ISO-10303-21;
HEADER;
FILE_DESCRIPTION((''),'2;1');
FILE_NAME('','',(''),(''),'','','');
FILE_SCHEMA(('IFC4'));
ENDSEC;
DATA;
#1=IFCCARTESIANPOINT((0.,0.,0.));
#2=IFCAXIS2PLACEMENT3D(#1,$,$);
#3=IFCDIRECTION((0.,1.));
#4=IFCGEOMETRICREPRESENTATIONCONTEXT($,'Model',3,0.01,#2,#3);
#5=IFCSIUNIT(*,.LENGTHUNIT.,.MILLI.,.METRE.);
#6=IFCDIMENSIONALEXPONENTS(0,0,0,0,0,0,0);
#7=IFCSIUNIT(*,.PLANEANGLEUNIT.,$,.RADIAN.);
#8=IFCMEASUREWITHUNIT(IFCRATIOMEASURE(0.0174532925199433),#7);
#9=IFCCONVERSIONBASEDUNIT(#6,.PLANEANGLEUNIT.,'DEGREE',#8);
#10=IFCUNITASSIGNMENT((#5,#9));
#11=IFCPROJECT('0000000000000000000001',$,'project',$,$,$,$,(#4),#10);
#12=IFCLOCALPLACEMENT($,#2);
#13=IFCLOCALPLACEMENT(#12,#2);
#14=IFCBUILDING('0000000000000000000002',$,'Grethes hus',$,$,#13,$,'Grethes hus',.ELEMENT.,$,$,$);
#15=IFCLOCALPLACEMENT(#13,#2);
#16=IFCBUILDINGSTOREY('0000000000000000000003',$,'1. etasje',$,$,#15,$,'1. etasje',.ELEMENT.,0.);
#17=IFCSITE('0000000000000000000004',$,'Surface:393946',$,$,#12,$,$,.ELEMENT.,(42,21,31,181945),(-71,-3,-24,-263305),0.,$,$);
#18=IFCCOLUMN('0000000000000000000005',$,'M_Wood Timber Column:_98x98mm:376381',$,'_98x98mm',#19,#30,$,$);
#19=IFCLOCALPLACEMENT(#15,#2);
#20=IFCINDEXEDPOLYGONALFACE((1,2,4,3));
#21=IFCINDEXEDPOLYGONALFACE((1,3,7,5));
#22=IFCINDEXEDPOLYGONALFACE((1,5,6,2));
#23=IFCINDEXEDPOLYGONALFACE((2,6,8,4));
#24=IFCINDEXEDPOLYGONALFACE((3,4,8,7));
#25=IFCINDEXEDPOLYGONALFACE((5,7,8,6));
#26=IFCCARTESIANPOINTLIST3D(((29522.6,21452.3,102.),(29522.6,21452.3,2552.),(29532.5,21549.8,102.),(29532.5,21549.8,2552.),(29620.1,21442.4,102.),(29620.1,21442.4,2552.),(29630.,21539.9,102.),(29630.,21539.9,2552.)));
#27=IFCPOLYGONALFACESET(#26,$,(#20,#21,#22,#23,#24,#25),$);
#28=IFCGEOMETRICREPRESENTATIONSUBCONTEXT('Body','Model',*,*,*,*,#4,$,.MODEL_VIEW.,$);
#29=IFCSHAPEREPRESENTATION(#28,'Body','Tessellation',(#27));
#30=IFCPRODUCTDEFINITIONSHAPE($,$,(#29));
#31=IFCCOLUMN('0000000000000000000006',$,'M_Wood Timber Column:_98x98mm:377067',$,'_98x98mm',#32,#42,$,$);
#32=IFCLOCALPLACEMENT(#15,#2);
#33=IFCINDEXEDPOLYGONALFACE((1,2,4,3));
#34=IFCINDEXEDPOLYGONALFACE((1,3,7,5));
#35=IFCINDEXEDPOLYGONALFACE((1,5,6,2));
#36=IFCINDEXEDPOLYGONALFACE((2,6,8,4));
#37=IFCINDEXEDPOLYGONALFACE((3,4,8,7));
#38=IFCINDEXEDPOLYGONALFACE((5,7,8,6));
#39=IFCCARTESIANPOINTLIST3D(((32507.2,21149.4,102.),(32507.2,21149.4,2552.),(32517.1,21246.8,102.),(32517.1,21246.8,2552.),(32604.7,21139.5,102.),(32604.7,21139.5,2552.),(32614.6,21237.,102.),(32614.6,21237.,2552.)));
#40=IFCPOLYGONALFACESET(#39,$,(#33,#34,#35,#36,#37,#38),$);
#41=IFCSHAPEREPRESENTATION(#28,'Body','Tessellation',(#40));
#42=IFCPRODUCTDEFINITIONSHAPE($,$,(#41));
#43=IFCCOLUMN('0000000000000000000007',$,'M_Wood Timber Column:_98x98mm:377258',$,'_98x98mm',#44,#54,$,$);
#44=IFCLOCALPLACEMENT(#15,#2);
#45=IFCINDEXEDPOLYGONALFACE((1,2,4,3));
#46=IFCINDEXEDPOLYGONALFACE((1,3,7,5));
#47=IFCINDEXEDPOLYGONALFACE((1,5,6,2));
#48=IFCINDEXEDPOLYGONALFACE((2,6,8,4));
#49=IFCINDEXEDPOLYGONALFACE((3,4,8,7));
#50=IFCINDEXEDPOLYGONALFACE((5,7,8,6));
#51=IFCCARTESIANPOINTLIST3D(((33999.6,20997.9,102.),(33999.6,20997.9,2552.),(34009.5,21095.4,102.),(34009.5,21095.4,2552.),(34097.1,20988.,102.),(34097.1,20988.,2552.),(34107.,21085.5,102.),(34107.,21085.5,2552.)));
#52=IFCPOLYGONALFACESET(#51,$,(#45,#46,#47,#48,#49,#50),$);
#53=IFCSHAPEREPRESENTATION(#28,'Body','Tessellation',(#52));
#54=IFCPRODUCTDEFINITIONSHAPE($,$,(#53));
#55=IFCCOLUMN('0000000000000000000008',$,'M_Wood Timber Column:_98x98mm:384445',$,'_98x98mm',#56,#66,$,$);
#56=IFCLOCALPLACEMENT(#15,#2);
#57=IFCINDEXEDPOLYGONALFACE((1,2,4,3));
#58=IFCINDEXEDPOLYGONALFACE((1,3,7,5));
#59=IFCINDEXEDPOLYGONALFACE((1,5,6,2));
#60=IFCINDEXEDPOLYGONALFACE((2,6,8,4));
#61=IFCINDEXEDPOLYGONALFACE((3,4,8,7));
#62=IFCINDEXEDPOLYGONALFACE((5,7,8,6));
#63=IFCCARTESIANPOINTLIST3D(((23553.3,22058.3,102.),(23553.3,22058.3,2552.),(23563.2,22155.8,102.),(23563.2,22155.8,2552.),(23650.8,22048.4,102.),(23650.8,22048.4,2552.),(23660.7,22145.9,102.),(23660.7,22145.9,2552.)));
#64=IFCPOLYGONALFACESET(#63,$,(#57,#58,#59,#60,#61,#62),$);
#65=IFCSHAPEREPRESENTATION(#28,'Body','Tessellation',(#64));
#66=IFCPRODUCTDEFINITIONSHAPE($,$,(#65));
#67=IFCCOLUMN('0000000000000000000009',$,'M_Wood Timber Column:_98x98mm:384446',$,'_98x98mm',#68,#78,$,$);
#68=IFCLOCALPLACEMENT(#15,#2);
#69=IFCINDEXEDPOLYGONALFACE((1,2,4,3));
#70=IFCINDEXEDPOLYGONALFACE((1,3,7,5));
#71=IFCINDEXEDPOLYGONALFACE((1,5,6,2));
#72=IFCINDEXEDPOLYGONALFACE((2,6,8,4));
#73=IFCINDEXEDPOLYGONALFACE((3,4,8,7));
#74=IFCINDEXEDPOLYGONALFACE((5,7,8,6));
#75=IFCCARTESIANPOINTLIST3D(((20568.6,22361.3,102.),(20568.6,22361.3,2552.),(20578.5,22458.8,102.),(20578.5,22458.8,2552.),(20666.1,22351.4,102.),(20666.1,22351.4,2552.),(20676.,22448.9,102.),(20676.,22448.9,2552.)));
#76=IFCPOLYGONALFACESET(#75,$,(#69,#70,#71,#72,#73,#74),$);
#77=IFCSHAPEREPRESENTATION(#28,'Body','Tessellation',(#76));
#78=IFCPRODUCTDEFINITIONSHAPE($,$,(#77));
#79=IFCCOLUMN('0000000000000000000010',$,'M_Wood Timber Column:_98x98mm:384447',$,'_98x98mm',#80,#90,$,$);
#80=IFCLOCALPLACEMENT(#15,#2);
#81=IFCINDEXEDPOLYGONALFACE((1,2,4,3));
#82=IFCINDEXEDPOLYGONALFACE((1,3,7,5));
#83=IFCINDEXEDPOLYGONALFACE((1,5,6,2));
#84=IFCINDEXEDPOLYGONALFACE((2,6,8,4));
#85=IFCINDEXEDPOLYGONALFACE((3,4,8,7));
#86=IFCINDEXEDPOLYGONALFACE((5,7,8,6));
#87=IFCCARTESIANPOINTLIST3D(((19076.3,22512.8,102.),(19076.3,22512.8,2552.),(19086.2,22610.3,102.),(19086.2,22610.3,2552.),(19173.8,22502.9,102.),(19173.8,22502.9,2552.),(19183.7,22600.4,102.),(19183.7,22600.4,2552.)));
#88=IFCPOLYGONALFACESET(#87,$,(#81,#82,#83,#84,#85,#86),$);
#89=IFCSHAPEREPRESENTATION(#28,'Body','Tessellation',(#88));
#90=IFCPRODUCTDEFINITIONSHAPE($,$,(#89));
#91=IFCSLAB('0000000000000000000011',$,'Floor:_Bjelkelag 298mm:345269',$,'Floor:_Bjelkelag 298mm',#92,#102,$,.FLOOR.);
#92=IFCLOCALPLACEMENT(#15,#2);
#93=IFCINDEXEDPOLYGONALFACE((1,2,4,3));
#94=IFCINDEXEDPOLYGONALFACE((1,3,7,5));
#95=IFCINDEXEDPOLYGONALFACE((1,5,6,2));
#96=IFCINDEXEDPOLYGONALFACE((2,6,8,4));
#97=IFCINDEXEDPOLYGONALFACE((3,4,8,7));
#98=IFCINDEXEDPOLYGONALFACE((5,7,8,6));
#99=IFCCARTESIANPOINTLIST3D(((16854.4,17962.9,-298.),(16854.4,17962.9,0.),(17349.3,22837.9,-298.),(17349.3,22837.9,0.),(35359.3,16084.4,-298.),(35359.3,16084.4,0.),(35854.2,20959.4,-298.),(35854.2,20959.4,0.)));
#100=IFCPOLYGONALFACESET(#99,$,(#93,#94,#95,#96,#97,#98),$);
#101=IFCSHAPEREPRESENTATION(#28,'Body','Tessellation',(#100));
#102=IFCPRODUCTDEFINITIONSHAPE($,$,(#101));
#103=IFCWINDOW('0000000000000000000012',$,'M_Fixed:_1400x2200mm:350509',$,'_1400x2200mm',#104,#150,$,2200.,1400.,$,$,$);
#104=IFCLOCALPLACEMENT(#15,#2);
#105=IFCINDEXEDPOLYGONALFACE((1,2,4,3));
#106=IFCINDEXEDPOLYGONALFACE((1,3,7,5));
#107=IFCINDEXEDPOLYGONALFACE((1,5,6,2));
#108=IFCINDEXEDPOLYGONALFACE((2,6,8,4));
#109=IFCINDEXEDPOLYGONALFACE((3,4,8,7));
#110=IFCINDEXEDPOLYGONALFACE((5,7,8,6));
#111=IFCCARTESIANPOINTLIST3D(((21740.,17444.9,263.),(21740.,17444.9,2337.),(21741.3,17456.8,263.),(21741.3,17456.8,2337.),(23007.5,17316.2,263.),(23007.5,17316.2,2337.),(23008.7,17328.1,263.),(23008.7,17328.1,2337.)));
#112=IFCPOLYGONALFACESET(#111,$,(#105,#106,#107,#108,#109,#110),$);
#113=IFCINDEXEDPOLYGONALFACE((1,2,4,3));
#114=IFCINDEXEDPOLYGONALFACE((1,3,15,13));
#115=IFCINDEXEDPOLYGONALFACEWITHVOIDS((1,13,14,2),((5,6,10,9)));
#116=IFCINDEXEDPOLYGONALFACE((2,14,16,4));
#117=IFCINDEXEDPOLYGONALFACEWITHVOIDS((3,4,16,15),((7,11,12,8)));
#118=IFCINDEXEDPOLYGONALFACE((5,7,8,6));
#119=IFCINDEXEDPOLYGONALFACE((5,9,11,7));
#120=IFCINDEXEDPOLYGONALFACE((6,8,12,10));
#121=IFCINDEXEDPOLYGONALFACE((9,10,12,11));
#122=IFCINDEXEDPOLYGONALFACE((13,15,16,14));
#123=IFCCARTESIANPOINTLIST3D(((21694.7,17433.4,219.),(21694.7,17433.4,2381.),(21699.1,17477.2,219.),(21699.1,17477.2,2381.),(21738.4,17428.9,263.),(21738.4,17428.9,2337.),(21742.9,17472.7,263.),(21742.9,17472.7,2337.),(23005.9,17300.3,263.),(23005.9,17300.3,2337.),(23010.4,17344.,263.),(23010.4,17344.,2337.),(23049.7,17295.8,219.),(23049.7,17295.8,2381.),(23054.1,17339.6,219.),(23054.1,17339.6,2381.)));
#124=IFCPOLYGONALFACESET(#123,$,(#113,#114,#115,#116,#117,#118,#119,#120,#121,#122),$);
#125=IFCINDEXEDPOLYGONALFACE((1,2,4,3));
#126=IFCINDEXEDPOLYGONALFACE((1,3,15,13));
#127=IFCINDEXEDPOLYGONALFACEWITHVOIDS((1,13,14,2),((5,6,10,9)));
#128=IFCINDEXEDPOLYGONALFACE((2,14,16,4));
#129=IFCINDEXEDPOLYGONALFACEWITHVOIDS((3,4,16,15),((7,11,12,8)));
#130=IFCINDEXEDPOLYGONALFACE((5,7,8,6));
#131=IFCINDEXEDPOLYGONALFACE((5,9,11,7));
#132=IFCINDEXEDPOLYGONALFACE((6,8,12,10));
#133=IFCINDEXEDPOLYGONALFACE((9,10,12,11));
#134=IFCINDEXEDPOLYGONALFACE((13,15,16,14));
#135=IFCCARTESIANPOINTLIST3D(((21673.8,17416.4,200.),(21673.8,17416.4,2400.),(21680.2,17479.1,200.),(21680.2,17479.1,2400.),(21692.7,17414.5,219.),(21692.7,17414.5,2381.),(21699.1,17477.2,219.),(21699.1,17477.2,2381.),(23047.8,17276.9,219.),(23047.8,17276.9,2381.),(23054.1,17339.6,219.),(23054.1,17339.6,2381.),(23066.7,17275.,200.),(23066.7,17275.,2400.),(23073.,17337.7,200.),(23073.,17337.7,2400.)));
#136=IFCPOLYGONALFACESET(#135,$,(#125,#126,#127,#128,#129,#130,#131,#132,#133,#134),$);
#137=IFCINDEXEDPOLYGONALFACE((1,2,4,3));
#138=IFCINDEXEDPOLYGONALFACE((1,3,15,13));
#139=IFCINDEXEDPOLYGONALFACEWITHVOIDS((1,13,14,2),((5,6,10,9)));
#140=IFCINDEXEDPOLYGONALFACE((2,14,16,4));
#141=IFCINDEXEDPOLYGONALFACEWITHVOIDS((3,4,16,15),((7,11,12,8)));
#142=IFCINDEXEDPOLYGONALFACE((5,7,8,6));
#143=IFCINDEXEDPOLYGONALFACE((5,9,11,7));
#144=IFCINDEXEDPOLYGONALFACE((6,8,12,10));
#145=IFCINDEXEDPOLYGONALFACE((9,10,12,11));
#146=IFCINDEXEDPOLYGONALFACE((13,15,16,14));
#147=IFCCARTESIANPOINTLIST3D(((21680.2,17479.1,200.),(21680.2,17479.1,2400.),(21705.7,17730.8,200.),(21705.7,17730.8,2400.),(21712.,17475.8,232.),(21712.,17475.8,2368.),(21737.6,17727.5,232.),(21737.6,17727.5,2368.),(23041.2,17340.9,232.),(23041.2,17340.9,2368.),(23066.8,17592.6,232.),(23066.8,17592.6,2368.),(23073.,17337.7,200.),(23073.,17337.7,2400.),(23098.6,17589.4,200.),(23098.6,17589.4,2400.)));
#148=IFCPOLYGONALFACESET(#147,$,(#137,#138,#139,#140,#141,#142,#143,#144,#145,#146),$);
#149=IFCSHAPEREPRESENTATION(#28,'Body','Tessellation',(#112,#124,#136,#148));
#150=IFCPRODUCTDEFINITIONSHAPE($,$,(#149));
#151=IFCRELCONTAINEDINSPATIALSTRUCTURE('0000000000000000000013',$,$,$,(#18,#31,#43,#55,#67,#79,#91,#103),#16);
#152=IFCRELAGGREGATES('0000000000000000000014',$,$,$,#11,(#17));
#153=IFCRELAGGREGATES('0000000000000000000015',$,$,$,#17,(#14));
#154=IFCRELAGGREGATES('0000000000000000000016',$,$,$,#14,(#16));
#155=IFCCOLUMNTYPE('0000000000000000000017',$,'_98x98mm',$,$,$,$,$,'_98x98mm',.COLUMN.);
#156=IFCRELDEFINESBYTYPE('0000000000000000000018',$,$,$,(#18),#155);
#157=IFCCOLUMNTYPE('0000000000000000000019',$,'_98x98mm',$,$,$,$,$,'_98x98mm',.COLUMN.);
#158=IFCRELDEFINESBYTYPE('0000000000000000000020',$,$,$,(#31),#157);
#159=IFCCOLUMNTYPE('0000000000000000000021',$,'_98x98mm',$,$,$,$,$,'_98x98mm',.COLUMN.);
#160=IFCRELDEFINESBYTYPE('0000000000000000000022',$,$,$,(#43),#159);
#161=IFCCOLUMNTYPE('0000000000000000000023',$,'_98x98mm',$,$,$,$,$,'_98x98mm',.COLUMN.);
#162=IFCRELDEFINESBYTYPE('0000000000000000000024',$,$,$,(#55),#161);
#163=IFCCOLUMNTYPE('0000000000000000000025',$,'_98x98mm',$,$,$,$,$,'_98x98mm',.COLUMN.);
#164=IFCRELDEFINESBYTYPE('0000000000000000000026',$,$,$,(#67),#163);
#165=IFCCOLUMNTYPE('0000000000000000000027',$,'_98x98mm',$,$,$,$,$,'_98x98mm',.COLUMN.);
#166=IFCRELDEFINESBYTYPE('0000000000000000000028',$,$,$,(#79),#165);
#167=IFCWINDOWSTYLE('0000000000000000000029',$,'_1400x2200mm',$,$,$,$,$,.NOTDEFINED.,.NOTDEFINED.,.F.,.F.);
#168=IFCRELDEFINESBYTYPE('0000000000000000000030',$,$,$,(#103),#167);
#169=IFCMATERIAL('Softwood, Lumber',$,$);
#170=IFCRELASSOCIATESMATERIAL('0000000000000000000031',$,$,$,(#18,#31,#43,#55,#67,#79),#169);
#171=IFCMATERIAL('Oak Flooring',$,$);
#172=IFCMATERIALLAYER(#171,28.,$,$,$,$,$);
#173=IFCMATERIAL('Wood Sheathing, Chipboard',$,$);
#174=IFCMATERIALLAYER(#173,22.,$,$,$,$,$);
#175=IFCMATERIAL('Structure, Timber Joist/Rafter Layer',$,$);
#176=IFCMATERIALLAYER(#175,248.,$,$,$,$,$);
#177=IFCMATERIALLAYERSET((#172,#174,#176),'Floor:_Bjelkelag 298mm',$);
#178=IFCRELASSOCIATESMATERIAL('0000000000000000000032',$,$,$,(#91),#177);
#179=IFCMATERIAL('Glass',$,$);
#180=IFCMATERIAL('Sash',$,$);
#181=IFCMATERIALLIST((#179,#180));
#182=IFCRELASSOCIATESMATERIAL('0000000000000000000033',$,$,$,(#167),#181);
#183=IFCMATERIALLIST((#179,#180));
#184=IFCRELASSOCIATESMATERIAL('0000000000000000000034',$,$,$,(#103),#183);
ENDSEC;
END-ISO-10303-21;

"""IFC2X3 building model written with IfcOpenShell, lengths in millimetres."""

from ifc_helpers import new_model, entity, si_unit, converted_unit, direction, frame, frame_2d, origin, place, context, subcontext, project, spatial, polyline, rectangle, outline, extrude, source, transform, mapped, material, material_list, layer, layer_set, layer_usage, type_object, type_shapes, element, save


model = new_model("IFC2X3")

# Units and contexts
model_context = context("Model", 3, precision=0.01, world=origin(), true_north=direction((0.0, 1.0)))
body_context = subcontext(model_context, "Body", "Model", "MODEL_VIEW")
ifc_project = project(units=[si_unit("LENGTHUNIT", "METRE", prefix="MILLI"), converted_unit("PLANEANGLEUNIT", "DEGREE", entity("IfcRatioMeasure", 0.0174532925199433), si_unit("PLANEANGLEUNIT", "RADIAN"), dimensions=[0, 0, 0, 0, 0, 0, 0])], contexts=[model_context])

# Site, building, storey
site_placement = place(None, origin())
site = spatial("IfcSite", under=ifc_project, at=site_placement, Name="Surface:393946", CompositionType="ELEMENT", RefLatitude=(42, 21, 31, 181945), RefLongitude=(-71, -3, -24, -263305), RefElevation=0.0)
building_placement = place(site_placement, origin())
building = spatial("IfcBuilding", under=site, at=building_placement, Name="Grethes hus", LongName="Grethes hus", CompositionType="ELEMENT")
storey_placement = place(building_placement, origin())
storey = spatial("IfcBuildingStorey", under=building, at=storey_placement, Name="1. etasje", LongName="1. etasje", CompositionType="ELEMENT", Elevation=0.0)

# Columns
ifc_material_1 = material(Name="Softwood, Lumber")
column_type_1 = type_object("IfcColumnType", Name="_98x98mm", ElementType="_98x98mm", PredefinedType="COLUMN")
shared_shape_1 = source(origin(), body_context, "Body", "SweptSolid", [
    extrude(rectangle(XDim=98.0, YDim=98.0, at=frame_2d((0.0, 0.0), x_axis=(1.0, 0.0))), frame((29576.3, 21496.1, 102.0), z_axis=(0.0, 0.0, 1.0), x_axis=(0.100996, 0.994887, 0.0)), (0.0, 0.0, 1.0), 2450.0),
])
type_shapes(column_type_1, [shared_shape_1])
column_1_placement = place(storey_placement, origin())
element("IfcColumn", 1, at=column_1_placement, inside=storey, type_object=column_type_1, material=ifc_material_1, Name="M_Wood Timber Column:_98x98mm:376381", ObjectType="_98x98mm", context=body_context, shape_type="MappedRepresentation", body=[
    mapped(shared_shape_1, transform((0.0, 0.0, 0.0), scale=1.0)),
])
column_type_2 = type_object("IfcColumnType", Name="_98x98mm", ElementType="_98x98mm", PredefinedType="COLUMN")
shared_shape_2 = source(origin(), body_context, "Body", "SweptSolid", [
    extrude(rectangle(XDim=98.0, YDim=98.0, at=frame_2d((0.0, 0.0), x_axis=(1.0, 0.0))), frame((32560.9, 21193.2, 102.0), z_axis=(0.0, 0.0, 1.0), x_axis=(0.100996, 0.994887, 0.0)), (0.0, 0.0, 1.0), 2450.0),
])
type_shapes(column_type_2, [shared_shape_2])
column_2_placement = place(storey_placement, origin())
element("IfcColumn", 2, at=column_2_placement, inside=storey, type_object=column_type_2, material=ifc_material_1, Name="M_Wood Timber Column:_98x98mm:377067", ObjectType="_98x98mm", context=body_context, shape_type="MappedRepresentation", body=[
    mapped(shared_shape_2, transform((0.0, 0.0, 0.0), scale=1.0)),
])
column_type_3 = type_object("IfcColumnType", Name="_98x98mm", ElementType="_98x98mm", PredefinedType="COLUMN")
shared_shape_3 = source(origin(), body_context, "Body", "SweptSolid", [
    extrude(rectangle(XDim=98.0, YDim=98.0, at=frame_2d((0.0, 0.0), x_axis=(1.0, 0.0))), frame((34053.3, 21041.7, 102.0), z_axis=(0.0, 0.0, 1.0), x_axis=(0.100996, 0.994887, 0.0)), (0.0, 0.0, 1.0), 2450.0),
])
type_shapes(column_type_3, [shared_shape_3])
column_3_placement = place(storey_placement, origin())
element("IfcColumn", 3, at=column_3_placement, inside=storey, type_object=column_type_3, material=ifc_material_1, Name="M_Wood Timber Column:_98x98mm:377258", ObjectType="_98x98mm", context=body_context, shape_type="MappedRepresentation", body=[
    mapped(shared_shape_3, transform((0.0, 0.0, 0.0), scale=1.0)),
])
column_type_4 = type_object("IfcColumnType", Name="_98x98mm", ElementType="_98x98mm", PredefinedType="COLUMN")
shared_shape_4 = source(origin(), body_context, "Body", "SweptSolid", [
    extrude(rectangle(XDim=98.0, YDim=98.0, at=frame_2d((0.0, 0.0), x_axis=(1.0, 0.0))), frame((23607.0, 22102.1, 102.0), z_axis=(0.0, 0.0, 1.0), x_axis=(0.100996, 0.994887, 0.0)), (0.0, 0.0, 1.0), 2450.0),
])
type_shapes(column_type_4, [shared_shape_4])
column_4_placement = place(storey_placement, origin())
element("IfcColumn", 4, at=column_4_placement, inside=storey, type_object=column_type_4, material=ifc_material_1, Name="M_Wood Timber Column:_98x98mm:384445", ObjectType="_98x98mm", context=body_context, shape_type="MappedRepresentation", body=[
    mapped(shared_shape_4, transform((0.0, 0.0, 0.0), scale=1.0)),
])
column_type_5 = type_object("IfcColumnType", Name="_98x98mm", ElementType="_98x98mm", PredefinedType="COLUMN")
shared_shape_5 = source(origin(), body_context, "Body", "SweptSolid", [
    extrude(rectangle(XDim=98.0, YDim=98.0, at=frame_2d((0.0, 0.0), x_axis=(1.0, 0.0))), frame((20622.3, 22405.1, 102.0), z_axis=(0.0, 0.0, 1.0), x_axis=(0.100996, 0.994887, 0.0)), (0.0, 0.0, 1.0), 2450.0),
])
type_shapes(column_type_5, [shared_shape_5])
column_5_placement = place(storey_placement, origin())
element("IfcColumn", 5, at=column_5_placement, inside=storey, type_object=column_type_5, material=ifc_material_1, Name="M_Wood Timber Column:_98x98mm:384446", ObjectType="_98x98mm", context=body_context, shape_type="MappedRepresentation", body=[
    mapped(shared_shape_5, transform((0.0, 0.0, 0.0), scale=1.0)),
])
column_type_6 = type_object("IfcColumnType", Name="_98x98mm", ElementType="_98x98mm", PredefinedType="COLUMN")
shared_shape_6 = source(origin(), body_context, "Body", "SweptSolid", [
    extrude(rectangle(XDim=98.0, YDim=98.0, at=frame_2d((0.0, 0.0), x_axis=(1.0, 0.0))), frame((19130.0, 22556.6, 102.0), z_axis=(0.0, 0.0, 1.0), x_axis=(0.100996, 0.994887, 0.0)), (0.0, 0.0, 1.0), 2450.0),
])
type_shapes(column_type_6, [shared_shape_6])
column_6_placement = place(storey_placement, origin())
element("IfcColumn", 6, at=column_6_placement, inside=storey, type_object=column_type_6, material=ifc_material_1, Name="M_Wood Timber Column:_98x98mm:384447", ObjectType="_98x98mm", context=body_context, shape_type="MappedRepresentation", body=[
    mapped(shared_shape_6, transform((0.0, 0.0, 0.0), scale=1.0)),
])

# Slab
ifc_material_2 = material(Name="Oak Flooring")
ifc_layer_1 = layer(ifc_material_2, 28.0)
ifc_material_3 = material(Name="Wood Sheathing, Chipboard")
ifc_layer_2 = layer(ifc_material_3, 22.0)
ifc_material_4 = material(Name="Structure, Timber Joist/Rafter Layer")
ifc_layer_3 = layer(ifc_material_4, 248.0)
ifc_layer_set = layer_set([ifc_layer_1, ifc_layer_2, ifc_layer_3], Name="Floor:_Bjelkelag 298mm")
ifc_layer_usage_1 = layer_usage(ifc_layer_set, "AXIS3", "POSITIVE", 0.0)
slab_1_placement = place(storey_placement, origin())
element("IfcSlab", 7, at=slab_1_placement, inside=storey, material=ifc_layer_usage_1, Name="Floor:_Bjelkelag 298mm:345269", ObjectType="Floor:_Bjelkelag 298mm", PredefinedType="FLOOR", context=body_context, shape_type="SweptSolid", body=[
    extrude(rectangle(XDim=18600.0, YDim=4900.0, at=frame_2d((0.0, 0.0), x_axis=(1.0, 0.0))), frame((26354.3, 19461.1, 0.0), z_axis=(0.0, 0.0, -1.0), x_axis=(0.994887, -0.100996, 0.0)), (0.0, 0.0, 1.0), 298.0),
])

# Window
ifc_material_5 = material(Name="Glass")
ifc_material_6 = material(Name="Sash")
ifc_material_list_1 = material_list([ifc_material_5, ifc_material_6])
ifc_material_list_2 = material_list([ifc_material_5, ifc_material_6])
window_style_1 = type_object("IfcWindowStyle", Name="_1400x2200mm", ConstructionType="NOTDEFINED", OperationType="NOTDEFINED", ParameterTakesPrecedence=False, Sizeable=False, material=ifc_material_list_2)
shared_shape_7 = source(origin(), body_context, "Body", "SweptSolid", [
    extrude(rectangle(XDim=12.0, YDim=1274.0, at=frame_2d((0.0, 0.0), x_axis=(1.0, 0.0))), frame((700.0, 275.0, 63.0), z_axis=(0.0, 0.0, 1.0), x_axis=(0.0, -1.0, 0.0)), (0.0, 0.0, 1.0), 2074.0),
    extrude(outline(polyline([(-681.0, -1081.0), (681.0, -1081.0), (681.0, 1081.0), (-681.0, 1081.0), (-681.0, -1081.0)]), holes=[polyline([(-637.0, -1037.0), (-637.0, 1037.0), (637.0, 1037.0), (637.0, -1037.0), (-637.0, -1037.0)])]), frame((700.0, 253.0, 1100.0), z_axis=(0.0, 1.0, 0.0), x_axis=(1.0, 0.0, 0.0)), (0.0, 0.0, 1.0), 44.0),
    extrude(outline(polyline([(-700.0, -1100.0), (700.0, -1100.0), (700.0, 1100.0), (-700.0, 1100.0), (-700.0, -1100.0)]), holes=[polyline([(-681.0, -1081.0), (-681.0, 1081.0), (681.0, 1081.0), (681.0, -1081.0), (-681.0, -1081.0)])]), frame((700.0, 253.0, 1100.0), z_axis=(0.0, 1.0, 0.0), x_axis=(1.0, 0.0, 0.0)), (0.0, 0.0, 1.0), 63.0),
    extrude(outline(polyline([(-700.0, -1100.0), (700.0, -1100.0), (700.0, 1100.0), (-700.0, 1100.0), (-700.0, -1100.0)]), holes=[polyline([(-668.0, -1068.0), (-668.0, 1068.0), (668.0, 1068.0), (668.0, -1068.0), (-668.0, -1068.0)])]), frame((700.0, 0.0, 1100.0), z_axis=(0.0, 1.0, 0.0), x_axis=(1.0, 0.0, 0.0)), (0.0, 0.0, 1.0), 253.0),
])
type_shapes(window_style_1, [shared_shape_7])
placement_1 = place(storey_placement, frame((35426.2, 16179.1, 0.0), z_axis=(0.0, 0.0, 1.0), x_axis=(-0.994887, 0.100996, 0.0)))
placement_2 = place(placement_1, frame((12407.0, -158.0, 200.0)))
window_1_placement = place(placement_2, origin())
element("IfcWindow", 8, at=window_1_placement, inside=storey, type_object=window_style_1, material=ifc_material_list_1, Name="M_Fixed:_1400x2200mm:350509", ObjectType="_1400x2200mm", OverallHeight=2200.0, OverallWidth=1400.0, context=body_context, shape_type="MappedRepresentation", body=[
    mapped(shared_shape_7, transform((0.0, 0.0, 0.0), scale=1.0)),
])

save(model, "model.ifc")
